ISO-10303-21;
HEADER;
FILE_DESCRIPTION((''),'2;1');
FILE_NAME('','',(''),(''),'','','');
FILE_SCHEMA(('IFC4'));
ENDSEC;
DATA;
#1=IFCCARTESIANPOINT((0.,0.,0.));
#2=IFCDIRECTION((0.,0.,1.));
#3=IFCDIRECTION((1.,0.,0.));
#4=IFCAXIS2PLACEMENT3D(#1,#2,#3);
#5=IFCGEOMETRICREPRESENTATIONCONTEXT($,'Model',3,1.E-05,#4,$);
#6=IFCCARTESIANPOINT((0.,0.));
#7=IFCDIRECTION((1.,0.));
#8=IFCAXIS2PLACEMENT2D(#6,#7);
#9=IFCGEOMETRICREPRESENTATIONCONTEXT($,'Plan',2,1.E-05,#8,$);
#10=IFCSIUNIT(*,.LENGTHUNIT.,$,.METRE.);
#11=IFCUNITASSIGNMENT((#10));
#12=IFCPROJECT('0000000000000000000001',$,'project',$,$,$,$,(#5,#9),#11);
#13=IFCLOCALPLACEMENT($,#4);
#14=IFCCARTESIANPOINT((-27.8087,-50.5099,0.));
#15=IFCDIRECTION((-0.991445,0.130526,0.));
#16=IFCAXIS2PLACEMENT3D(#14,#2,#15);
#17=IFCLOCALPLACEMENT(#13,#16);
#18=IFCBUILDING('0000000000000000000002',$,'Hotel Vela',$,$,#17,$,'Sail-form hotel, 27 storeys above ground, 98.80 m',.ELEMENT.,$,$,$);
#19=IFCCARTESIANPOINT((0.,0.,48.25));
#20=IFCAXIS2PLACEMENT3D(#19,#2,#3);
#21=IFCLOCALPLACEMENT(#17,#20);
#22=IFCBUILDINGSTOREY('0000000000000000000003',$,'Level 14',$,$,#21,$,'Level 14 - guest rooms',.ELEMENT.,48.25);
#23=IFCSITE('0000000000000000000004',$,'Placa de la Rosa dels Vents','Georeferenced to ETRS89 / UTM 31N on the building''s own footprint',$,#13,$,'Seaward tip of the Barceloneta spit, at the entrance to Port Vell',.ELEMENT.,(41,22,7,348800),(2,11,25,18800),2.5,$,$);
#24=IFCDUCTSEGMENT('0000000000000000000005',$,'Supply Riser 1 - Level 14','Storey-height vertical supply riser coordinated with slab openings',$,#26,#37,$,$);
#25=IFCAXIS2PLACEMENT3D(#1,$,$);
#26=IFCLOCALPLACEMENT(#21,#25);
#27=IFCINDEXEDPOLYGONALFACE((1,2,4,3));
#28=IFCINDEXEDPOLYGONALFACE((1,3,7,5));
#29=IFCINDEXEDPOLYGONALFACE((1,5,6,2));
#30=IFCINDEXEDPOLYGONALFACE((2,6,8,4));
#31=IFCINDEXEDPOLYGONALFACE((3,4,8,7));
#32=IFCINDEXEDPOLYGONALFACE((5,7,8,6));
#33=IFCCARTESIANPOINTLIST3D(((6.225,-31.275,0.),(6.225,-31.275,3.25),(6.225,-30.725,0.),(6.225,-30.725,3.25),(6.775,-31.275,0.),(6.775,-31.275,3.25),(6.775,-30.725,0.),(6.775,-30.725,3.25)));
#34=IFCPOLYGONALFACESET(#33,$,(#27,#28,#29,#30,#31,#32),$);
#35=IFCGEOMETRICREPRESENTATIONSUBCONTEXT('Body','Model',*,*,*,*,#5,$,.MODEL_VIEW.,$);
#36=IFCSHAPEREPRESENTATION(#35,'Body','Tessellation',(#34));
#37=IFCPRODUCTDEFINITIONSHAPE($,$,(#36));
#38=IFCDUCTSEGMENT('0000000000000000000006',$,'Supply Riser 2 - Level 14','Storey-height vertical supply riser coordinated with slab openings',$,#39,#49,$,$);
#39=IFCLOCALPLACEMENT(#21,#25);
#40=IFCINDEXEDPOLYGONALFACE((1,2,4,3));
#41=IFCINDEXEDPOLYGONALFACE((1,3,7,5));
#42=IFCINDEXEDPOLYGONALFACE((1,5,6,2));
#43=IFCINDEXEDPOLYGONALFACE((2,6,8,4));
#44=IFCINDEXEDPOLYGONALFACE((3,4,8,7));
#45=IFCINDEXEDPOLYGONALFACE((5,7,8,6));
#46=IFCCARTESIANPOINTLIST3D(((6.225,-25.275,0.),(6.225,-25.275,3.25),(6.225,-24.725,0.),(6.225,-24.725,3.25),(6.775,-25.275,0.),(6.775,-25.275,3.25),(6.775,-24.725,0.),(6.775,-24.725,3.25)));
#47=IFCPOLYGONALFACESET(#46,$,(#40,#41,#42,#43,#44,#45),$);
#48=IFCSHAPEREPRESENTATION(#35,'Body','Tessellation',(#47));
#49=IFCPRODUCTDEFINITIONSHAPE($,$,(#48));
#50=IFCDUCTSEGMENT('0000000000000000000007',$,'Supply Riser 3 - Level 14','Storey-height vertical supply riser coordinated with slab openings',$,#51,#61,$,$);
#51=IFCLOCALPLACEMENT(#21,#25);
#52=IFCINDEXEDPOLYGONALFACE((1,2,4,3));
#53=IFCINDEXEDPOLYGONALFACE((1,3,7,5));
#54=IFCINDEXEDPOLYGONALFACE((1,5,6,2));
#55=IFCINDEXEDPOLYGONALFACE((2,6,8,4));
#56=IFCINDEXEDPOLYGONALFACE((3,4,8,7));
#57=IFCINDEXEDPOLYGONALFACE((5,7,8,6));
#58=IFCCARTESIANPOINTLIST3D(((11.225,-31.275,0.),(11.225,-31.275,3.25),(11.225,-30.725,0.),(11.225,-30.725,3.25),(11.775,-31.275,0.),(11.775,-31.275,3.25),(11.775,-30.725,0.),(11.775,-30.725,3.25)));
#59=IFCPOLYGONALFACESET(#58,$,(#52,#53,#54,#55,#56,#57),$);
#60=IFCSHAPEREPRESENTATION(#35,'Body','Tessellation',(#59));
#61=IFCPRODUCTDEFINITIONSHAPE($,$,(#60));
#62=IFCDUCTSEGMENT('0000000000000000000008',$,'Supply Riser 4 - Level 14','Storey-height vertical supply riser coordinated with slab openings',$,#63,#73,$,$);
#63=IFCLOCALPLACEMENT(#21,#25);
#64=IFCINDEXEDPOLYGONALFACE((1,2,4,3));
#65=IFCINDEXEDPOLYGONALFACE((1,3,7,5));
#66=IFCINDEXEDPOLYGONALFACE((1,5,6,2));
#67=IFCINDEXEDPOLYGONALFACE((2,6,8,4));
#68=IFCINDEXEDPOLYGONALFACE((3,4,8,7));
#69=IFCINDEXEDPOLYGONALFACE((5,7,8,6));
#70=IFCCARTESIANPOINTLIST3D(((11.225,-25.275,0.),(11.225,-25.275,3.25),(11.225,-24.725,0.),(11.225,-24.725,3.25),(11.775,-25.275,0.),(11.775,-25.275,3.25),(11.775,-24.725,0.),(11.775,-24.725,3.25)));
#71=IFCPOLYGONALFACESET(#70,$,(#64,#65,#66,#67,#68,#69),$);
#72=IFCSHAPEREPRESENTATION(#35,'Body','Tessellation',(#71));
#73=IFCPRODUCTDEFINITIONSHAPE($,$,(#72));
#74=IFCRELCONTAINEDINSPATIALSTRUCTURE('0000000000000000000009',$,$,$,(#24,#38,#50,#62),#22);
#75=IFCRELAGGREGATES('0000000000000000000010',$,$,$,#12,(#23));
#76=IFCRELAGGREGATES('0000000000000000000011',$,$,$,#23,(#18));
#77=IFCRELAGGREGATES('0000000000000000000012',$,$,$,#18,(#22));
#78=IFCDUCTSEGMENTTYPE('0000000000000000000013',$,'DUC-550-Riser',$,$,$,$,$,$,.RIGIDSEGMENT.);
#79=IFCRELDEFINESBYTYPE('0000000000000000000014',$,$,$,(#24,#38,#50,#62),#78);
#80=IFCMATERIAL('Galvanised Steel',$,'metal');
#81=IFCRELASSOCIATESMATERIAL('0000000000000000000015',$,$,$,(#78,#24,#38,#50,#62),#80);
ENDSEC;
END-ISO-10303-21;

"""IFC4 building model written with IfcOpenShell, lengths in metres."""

from ifc_helpers import new_model, si_unit, frame, origin_with_axes, origin_2d_with_axis, place, context, subcontext, project, spatial, line, indexed_curve, outline, extrude, material, type_object, element, save


model = new_model("IFC4")

# Units and contexts
model_context = context("Model", 3, precision=1e-05, world=origin_with_axes())
plan_context = context("Plan", 2, precision=1e-05, world=origin_2d_with_axis())
body_context = subcontext(model_context, "Body", "Model", "MODEL_VIEW")
ifc_project = project(units=[si_unit("LENGTHUNIT", "METRE")], contexts=[model_context, plan_context])

# Site, building, storey
site_placement = place(None, origin_with_axes())
site = spatial("IfcSite", under=ifc_project, at=site_placement, Name="Placa de la Rosa dels Vents", Description="Georeferenced to ETRS89 / UTM 31N on the building's own footprint", LongName="Seaward tip of the Barceloneta spit, at the entrance to Port Vell", CompositionType="ELEMENT", RefLatitude=(41, 22, 7, 348800), RefLongitude=(2, 11, 25, 18800), RefElevation=2.5)
building_placement = place(site_placement, frame((-27.8087, -50.5099, 0.0), z_axis=(0.0, 0.0, 1.0), x_axis=(-0.991445, 0.130526, 0.0)))
building = spatial("IfcBuilding", under=site, at=building_placement, Name="Hotel Vela", LongName="Sail-form hotel, 27 storeys above ground, 98.80 m", CompositionType="ELEMENT")
storey_placement = place(building_placement, frame((0.0, 0.0, 48.25), z_axis=(0.0, 0.0, 1.0), x_axis=(1.0, 0.0, 0.0)))
storey = spatial("IfcBuildingStorey", under=building, at=storey_placement, Name="Level 14", LongName="Level 14 - guest rooms", CompositionType="ELEMENT", Elevation=48.25)

# Duct segments
ifc_material = material(Name="Galvanised Steel", Category="metal")
duct_segment_type = type_object("IfcDuctSegmentType", Name="DUC-550-Riser", PredefinedType="RIGIDSEGMENT", material=ifc_material)
for number, where, z_axis, x_axis, name in (
    (1, (6.225, -31.275, 0.0), (0.0, 0.0, 1.0), (1.0, 0.0, 0.0), "Supply Riser 1 - Level 14"),
    (2, (6.225, -25.275, 0.0), (0.0, 0.0, 1.0), (1.0, 0.0, 0.0), "Supply Riser 2 - Level 14"),
    (3, (11.225, -31.275, 0.0), (0.0, 0.0, 1.0), (1.0, 0.0, 0.0), "Supply Riser 3 - Level 14"),
    (4, (11.225, -25.275, 0.0), (0.0, 0.0, 1.0), (1.0, 0.0, 0.0), "Supply Riser 4 - Level 14"),
):
    element("IfcDuctSegment", number, at=place(storey_placement, frame(where, z_axis=z_axis, x_axis=x_axis)), inside=storey, type_object=duct_segment_type, material=ifc_material, Name=name, Description="Storey-height vertical supply riser coordinated with slab openings", context=body_context, shape_type="SweptSolid", body=[
        extrude(outline(indexed_curve([(0.0, 0.0), (0.55, 0.0), (0.55, 0.55), (0.0, 0.55)], segments=[line(1, 2, 3, 4, 1)])), origin_with_axes(), (0.0, 0.0, 1.0), 3.25),
    ])

save(model, "model.ifc")
